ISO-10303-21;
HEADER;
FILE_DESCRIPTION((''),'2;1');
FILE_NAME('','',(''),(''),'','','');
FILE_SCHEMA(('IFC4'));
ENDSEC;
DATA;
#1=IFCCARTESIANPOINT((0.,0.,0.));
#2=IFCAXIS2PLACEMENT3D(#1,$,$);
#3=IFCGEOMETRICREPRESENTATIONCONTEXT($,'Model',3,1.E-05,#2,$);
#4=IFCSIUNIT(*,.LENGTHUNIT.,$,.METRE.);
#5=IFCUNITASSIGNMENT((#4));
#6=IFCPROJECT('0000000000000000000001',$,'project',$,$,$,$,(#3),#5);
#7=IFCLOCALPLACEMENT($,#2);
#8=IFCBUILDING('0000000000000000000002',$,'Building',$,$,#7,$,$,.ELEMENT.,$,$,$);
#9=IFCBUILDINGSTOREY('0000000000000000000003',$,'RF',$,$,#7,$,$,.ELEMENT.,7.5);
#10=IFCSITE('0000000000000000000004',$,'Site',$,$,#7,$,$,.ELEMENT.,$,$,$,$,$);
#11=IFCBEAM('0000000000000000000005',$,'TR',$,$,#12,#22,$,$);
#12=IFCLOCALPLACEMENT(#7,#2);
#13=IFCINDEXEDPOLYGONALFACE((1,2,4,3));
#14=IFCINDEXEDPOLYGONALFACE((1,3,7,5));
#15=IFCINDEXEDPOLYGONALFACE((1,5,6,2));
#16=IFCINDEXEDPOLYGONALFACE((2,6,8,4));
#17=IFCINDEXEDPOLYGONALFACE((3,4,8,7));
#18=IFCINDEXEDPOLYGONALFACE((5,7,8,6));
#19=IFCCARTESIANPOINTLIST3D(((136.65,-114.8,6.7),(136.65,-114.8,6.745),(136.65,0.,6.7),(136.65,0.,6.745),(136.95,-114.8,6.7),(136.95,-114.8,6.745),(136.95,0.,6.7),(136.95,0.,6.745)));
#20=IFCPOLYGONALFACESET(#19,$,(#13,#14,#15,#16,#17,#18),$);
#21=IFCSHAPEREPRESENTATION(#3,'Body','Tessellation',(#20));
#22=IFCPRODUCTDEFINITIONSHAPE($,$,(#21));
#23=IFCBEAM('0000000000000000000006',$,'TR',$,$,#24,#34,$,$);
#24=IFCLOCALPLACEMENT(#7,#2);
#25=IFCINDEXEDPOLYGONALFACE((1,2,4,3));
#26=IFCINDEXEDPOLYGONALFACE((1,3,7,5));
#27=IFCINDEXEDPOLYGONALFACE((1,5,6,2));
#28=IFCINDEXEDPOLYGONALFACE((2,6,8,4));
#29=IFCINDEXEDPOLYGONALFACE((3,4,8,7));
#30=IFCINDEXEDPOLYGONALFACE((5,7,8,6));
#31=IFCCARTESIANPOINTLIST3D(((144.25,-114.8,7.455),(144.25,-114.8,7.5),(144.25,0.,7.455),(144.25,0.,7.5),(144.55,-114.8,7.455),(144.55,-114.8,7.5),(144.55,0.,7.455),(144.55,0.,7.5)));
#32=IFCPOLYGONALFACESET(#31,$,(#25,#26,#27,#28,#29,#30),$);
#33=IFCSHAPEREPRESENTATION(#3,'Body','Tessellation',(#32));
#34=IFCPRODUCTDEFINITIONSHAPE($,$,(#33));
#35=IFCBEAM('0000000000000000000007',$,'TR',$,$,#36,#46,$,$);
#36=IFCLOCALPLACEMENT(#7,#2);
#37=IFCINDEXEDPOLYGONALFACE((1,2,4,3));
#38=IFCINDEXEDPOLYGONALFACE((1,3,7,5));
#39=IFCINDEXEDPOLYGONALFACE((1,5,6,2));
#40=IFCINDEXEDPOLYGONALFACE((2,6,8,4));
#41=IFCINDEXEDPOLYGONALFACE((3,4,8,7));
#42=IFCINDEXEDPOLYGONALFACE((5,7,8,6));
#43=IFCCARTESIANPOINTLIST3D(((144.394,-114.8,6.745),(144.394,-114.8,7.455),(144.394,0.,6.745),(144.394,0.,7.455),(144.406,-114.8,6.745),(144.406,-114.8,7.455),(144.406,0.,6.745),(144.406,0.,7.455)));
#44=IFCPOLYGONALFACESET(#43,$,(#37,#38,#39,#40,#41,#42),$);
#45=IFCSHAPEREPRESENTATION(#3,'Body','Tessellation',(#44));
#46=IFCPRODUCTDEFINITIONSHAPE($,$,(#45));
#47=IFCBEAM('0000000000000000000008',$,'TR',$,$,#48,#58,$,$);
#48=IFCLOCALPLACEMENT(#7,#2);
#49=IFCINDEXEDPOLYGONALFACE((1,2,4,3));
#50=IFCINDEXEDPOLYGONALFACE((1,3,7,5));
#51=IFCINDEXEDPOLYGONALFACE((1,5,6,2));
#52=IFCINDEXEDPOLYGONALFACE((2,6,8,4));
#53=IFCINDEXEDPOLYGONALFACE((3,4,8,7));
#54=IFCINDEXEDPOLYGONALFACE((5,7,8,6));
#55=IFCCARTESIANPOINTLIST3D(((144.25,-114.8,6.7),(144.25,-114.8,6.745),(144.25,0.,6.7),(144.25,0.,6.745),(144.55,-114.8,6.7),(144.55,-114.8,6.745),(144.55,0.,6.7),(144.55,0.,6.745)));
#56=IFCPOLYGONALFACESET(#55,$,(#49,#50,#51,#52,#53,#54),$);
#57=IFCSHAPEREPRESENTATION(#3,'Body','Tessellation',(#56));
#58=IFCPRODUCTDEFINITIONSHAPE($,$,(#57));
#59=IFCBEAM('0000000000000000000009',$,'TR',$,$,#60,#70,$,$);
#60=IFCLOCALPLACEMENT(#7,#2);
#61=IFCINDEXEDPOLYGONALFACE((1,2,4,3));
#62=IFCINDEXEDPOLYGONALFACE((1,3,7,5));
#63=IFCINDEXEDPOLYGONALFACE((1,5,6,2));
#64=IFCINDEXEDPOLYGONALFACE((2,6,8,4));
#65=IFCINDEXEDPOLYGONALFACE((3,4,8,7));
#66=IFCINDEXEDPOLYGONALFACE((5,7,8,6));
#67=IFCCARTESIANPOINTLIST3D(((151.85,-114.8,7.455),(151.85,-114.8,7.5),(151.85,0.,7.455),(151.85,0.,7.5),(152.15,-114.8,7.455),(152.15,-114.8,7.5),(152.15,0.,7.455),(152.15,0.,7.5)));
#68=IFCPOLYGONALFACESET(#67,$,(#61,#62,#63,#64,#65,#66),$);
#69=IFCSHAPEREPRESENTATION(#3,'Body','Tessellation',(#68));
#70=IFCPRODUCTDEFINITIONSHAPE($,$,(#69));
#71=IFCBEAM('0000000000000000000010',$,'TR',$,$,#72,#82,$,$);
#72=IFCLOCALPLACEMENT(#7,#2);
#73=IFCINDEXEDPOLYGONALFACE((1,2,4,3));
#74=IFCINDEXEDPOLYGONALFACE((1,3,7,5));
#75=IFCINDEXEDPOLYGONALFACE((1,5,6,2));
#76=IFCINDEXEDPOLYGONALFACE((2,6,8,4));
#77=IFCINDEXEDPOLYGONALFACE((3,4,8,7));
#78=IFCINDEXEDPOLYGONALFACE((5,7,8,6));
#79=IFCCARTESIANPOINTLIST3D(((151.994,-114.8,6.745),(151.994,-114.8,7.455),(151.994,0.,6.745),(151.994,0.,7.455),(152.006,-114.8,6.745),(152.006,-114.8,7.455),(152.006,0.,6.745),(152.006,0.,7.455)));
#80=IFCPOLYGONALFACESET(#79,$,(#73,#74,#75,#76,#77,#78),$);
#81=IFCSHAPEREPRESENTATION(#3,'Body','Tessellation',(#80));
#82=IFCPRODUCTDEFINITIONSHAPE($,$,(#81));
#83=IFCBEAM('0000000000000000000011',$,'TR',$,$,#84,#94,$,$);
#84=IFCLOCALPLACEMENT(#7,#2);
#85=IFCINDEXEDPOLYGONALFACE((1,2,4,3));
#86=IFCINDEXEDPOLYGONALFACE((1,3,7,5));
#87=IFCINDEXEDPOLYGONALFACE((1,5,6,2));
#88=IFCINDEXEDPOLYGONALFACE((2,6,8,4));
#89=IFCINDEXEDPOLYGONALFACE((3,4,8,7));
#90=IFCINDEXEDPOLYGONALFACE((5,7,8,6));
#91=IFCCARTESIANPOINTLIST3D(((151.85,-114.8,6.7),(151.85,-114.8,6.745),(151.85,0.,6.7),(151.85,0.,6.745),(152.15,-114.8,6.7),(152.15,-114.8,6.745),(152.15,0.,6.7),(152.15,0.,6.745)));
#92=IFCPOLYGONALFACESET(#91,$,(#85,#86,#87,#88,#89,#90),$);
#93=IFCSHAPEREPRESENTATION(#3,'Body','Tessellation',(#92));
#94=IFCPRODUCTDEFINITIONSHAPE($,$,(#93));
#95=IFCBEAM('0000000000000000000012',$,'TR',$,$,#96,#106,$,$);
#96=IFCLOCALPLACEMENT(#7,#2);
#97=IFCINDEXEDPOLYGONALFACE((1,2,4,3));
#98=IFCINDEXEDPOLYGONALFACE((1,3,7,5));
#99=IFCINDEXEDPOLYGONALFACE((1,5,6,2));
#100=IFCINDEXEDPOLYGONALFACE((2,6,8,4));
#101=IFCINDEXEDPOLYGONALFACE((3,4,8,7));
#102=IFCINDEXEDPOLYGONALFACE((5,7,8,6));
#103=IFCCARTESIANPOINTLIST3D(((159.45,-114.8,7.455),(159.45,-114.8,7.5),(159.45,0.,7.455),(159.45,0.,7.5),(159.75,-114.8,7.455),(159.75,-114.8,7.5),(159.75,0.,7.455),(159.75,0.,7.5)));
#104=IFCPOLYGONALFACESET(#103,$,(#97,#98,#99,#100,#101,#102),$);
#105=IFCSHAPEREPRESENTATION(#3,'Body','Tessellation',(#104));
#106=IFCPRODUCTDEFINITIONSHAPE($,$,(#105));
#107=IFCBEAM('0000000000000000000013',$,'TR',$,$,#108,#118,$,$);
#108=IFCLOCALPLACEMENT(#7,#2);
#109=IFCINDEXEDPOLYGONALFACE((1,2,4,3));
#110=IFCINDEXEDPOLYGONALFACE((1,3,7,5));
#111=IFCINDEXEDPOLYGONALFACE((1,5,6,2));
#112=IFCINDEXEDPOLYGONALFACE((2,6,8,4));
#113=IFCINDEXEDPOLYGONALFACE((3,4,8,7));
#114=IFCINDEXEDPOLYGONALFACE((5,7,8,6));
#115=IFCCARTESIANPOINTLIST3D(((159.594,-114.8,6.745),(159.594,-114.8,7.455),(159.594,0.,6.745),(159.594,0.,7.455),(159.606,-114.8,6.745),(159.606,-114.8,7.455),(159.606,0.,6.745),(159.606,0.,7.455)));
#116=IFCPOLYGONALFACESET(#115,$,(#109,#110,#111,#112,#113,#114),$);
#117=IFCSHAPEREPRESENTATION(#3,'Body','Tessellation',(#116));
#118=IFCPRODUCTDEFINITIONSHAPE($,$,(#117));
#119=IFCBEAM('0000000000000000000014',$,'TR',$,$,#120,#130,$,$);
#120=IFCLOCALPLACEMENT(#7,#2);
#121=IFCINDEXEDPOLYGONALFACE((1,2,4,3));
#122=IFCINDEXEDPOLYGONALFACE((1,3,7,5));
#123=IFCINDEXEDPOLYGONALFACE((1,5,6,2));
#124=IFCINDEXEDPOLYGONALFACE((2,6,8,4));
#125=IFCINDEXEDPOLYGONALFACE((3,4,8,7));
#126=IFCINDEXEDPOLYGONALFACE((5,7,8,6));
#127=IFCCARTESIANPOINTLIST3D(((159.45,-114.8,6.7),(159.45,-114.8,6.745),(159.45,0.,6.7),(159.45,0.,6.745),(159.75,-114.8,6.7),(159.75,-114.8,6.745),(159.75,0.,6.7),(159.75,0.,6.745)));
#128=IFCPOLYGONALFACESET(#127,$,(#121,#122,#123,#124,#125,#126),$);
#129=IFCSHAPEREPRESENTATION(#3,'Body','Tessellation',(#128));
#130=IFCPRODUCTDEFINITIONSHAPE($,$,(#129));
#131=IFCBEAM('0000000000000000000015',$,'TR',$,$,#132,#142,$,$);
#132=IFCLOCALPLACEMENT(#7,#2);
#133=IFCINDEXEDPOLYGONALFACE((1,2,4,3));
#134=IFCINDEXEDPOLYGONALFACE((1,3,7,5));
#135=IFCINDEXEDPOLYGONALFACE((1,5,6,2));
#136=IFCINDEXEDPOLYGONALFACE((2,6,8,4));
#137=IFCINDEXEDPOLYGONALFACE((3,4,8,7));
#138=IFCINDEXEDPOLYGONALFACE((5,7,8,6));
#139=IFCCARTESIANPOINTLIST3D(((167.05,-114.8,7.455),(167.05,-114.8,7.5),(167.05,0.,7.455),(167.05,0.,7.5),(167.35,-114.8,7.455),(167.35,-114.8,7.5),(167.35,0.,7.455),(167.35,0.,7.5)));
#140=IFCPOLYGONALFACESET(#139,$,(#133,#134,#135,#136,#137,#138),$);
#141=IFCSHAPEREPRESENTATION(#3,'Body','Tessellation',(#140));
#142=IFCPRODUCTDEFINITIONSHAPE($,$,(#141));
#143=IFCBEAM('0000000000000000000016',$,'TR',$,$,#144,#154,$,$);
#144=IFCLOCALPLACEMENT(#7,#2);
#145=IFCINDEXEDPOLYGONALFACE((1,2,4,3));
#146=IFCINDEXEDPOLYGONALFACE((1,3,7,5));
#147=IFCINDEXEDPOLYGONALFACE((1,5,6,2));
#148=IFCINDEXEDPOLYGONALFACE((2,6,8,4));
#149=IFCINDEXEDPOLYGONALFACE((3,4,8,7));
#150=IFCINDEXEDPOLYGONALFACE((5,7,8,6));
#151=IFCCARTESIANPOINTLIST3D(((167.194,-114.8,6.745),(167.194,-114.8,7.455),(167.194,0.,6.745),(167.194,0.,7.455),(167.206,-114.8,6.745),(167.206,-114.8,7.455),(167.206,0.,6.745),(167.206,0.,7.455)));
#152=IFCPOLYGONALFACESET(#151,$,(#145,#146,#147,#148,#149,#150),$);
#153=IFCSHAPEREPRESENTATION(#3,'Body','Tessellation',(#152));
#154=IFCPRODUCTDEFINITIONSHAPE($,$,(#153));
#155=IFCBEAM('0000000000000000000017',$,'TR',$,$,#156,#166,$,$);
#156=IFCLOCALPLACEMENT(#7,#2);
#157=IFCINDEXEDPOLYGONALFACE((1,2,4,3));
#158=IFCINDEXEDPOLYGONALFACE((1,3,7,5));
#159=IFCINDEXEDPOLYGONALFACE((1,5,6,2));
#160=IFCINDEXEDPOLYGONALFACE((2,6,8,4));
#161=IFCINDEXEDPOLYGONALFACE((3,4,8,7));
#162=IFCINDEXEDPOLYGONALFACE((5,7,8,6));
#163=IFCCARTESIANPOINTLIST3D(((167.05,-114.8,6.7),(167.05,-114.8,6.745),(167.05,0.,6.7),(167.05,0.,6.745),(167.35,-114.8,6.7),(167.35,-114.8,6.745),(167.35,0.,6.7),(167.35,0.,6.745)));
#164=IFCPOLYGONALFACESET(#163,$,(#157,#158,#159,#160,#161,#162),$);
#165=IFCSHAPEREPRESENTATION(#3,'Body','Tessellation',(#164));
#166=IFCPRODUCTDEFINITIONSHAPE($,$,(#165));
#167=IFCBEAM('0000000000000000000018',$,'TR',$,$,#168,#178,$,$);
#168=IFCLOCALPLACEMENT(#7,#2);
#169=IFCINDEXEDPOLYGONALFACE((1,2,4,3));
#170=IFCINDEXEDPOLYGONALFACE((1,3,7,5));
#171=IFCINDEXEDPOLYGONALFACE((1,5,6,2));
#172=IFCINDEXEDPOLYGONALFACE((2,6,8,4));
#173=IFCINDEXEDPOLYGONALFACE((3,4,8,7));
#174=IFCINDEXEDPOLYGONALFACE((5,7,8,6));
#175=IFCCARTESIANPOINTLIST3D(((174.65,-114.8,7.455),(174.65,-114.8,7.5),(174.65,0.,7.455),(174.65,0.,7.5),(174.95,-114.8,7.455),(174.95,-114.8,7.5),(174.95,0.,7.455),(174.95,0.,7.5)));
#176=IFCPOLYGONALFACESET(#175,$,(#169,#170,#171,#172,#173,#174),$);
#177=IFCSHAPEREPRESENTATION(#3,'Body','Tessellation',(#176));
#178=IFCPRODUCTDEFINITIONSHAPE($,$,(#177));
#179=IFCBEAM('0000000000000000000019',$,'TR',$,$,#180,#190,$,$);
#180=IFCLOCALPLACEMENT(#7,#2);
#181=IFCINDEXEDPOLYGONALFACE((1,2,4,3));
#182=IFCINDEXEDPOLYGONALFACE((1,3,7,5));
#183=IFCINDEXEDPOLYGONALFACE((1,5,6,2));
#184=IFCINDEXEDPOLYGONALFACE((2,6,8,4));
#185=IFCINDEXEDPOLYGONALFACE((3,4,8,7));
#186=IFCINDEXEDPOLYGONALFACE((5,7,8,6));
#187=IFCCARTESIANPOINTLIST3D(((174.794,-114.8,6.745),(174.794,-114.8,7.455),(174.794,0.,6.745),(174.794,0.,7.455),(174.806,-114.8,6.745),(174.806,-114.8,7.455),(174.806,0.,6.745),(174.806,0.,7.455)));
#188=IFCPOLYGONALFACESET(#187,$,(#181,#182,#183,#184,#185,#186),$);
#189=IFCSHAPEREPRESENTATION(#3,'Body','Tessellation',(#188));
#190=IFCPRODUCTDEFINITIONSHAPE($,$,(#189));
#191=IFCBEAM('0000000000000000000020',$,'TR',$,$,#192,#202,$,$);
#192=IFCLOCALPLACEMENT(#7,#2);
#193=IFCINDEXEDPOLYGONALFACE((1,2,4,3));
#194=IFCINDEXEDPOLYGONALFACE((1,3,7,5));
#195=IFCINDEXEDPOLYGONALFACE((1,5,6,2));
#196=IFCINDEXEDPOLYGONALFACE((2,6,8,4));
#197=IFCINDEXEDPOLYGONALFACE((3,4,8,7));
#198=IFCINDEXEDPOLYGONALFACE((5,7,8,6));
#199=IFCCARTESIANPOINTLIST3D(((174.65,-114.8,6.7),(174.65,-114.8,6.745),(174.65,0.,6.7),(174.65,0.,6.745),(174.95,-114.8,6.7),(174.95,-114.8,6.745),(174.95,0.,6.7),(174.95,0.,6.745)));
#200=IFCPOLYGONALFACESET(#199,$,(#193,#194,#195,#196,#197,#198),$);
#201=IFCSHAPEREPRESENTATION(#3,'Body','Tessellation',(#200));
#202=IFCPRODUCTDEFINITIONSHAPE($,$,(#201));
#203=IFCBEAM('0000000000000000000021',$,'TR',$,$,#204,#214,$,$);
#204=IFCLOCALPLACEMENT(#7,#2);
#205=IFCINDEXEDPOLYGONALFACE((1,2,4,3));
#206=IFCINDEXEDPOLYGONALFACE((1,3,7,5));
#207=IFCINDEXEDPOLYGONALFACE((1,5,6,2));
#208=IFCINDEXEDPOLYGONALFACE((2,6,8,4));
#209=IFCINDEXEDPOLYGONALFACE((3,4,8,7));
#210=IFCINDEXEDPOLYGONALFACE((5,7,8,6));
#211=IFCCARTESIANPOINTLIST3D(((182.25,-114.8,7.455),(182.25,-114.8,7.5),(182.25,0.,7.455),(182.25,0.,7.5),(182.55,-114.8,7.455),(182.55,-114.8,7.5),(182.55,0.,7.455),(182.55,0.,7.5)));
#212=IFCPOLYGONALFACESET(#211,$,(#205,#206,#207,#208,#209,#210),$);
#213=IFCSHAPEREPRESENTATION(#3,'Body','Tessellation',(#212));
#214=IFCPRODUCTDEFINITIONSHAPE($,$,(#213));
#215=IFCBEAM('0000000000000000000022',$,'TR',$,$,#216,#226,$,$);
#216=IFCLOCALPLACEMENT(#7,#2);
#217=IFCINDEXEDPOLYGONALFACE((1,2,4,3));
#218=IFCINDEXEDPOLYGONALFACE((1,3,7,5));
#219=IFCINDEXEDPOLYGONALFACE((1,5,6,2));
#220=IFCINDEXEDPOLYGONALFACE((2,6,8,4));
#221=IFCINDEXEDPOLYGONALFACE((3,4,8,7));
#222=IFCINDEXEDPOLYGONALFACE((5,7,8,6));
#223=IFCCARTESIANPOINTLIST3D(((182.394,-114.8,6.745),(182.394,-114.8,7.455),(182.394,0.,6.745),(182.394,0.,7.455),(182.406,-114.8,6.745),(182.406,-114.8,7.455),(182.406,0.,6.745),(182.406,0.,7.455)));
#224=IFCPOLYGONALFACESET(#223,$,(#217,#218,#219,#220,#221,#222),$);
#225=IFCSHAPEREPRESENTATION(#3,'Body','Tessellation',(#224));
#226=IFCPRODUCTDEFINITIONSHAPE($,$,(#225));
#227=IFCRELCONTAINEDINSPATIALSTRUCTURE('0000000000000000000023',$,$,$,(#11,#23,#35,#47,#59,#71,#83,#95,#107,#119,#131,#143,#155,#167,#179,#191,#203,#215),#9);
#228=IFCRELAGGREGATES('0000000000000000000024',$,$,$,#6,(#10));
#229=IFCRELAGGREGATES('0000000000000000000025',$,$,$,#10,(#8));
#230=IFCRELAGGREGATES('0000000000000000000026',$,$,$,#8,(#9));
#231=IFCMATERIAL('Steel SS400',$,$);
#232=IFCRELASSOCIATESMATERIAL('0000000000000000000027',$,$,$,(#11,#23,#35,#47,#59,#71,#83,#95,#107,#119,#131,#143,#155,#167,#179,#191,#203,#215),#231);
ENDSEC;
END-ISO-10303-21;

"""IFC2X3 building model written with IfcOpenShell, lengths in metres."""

from ifc_helpers import new_model, si_unit, frame, origin, origin_2d, place, context, project, spatial, rectangle, extrude, material, element, save


model = new_model("IFC2X3")

# Units and contexts
model_context = context("Model", 3, precision=1e-05, world=origin())
ifc_project = project(units=[si_unit("LENGTHUNIT", "METRE")], contexts=[model_context])

# Site, building, storey
placement = place(None, origin())
site = spatial("IfcSite", under=ifc_project, at=placement, Name="Site", CompositionType="ELEMENT")
building = spatial("IfcBuilding", under=site, at=placement, Name="Building", CompositionType="ELEMENT")
storey = spatial("IfcBuildingStorey", under=building, at=placement, Name="RF", CompositionType="ELEMENT", Elevation=7.5)

# Beams
ifc_material = material(Name="Steel SS400")
for number, where, name in (
    (1, (136.8, -57.4, 6.7), "TR"),
    (2, (144.4, -57.4, 7.455), "TR"),
):
    element("IfcBeam", number, at=place(None, frame(where)), inside=storey, material=ifc_material, Name=name, context=model_context, shape_type="SweptSolid", body=[
        extrude(rectangle(XDim=0.3, YDim=114.8, at=origin_2d()), origin(), (0.0, 0.0, 1.0), 0.045),
    ])
beam_1_placement = place(None, frame((144.4, -57.4, 6.745)))
element("IfcBeam", 3, at=beam_1_placement, inside=storey, material=ifc_material, Name="TR", context=model_context, shape_type="SweptSolid", body=[
    extrude(rectangle(XDim=0.012, YDim=114.8, at=origin_2d()), origin(), (0.0, 0.0, 1.0), 0.71),
])
for number, where, name in (
    (4, (144.4, -57.4, 6.7), "TR"),
    (5, (152.0, -57.4, 7.455), "TR"),
):
    element("IfcBeam", number, at=place(None, frame(where)), inside=storey, material=ifc_material, Name=name, context=model_context, shape_type="SweptSolid", body=[
        extrude(rectangle(XDim=0.3, YDim=114.8, at=origin_2d()), origin(), (0.0, 0.0, 1.0), 0.045),
    ])
beam_2_placement = place(None, frame((152.0, -57.4, 6.745)))
element("IfcBeam", 6, at=beam_2_placement, inside=storey, material=ifc_material, Name="TR", context=model_context, shape_type="SweptSolid", body=[
    extrude(rectangle(XDim=0.012, YDim=114.8, at=origin_2d()), origin(), (0.0, 0.0, 1.0), 0.71),
])
for number, where, name in (
    (7, (152.0, -57.4, 6.7), "TR"),
    (8, (159.6, -57.4, 7.455), "TR"),
):
    element("IfcBeam", number, at=place(None, frame(where)), inside=storey, material=ifc_material, Name=name, context=model_context, shape_type="SweptSolid", body=[
        extrude(rectangle(XDim=0.3, YDim=114.8, at=origin_2d()), origin(), (0.0, 0.0, 1.0), 0.045),
    ])
beam_3_placement = place(None, frame((159.6, -57.4, 6.745)))
element("IfcBeam", 9, at=beam_3_placement, inside=storey, material=ifc_material, Name="TR", context=model_context, shape_type="SweptSolid", body=[
    extrude(rectangle(XDim=0.012, YDim=114.8, at=origin_2d()), origin(), (0.0, 0.0, 1.0), 0.71),
])
for number, where, name in (
    (10, (159.6, -57.4, 6.7), "TR"),
    (11, (167.2, -57.4, 7.455), "TR"),
):
    element("IfcBeam", number, at=place(None, frame(where)), inside=storey, material=ifc_material, Name=name, context=model_context, shape_type="SweptSolid", body=[
        extrude(rectangle(XDim=0.3, YDim=114.8, at=origin_2d()), origin(), (0.0, 0.0, 1.0), 0.045),
    ])
beam_4_placement = place(None, frame((167.2, -57.4, 6.745)))
element("IfcBeam", 12, at=beam_4_placement, inside=storey, material=ifc_material, Name="TR", context=model_context, shape_type="SweptSolid", body=[
    extrude(rectangle(XDim=0.012, YDim=114.8, at=origin_2d()), origin(), (0.0, 0.0, 1.0), 0.71),
])
for number, where, name in (
    (13, (167.2, -57.4, 6.7), "TR"),
    (14, (174.8, -57.4, 7.455), "TR"),
):
    element("IfcBeam", number, at=place(None, frame(where)), inside=storey, material=ifc_material, Name=name, context=model_context, shape_type="SweptSolid", body=[
        extrude(rectangle(XDim=0.3, YDim=114.8, at=origin_2d()), origin(), (0.0, 0.0, 1.0), 0.045),
    ])
beam_5_placement = place(None, frame((174.8, -57.4, 6.745)))
element("IfcBeam", 15, at=beam_5_placement, inside=storey, material=ifc_material, Name="TR", context=model_context, shape_type="SweptSolid", body=[
    extrude(rectangle(XDim=0.012, YDim=114.8, at=origin_2d()), origin(), (0.0, 0.0, 1.0), 0.71),
])
for number, where, name in (
    (16, (174.8, -57.4, 6.7), "TR"),
    (17, (182.4, -57.4, 7.455), "TR"),
):
    element("IfcBeam", number, at=place(None, frame(where)), inside=storey, material=ifc_material, Name=name, context=model_context, shape_type="SweptSolid", body=[
        extrude(rectangle(XDim=0.3, YDim=114.8, at=origin_2d()), origin(), (0.0, 0.0, 1.0), 0.045),
    ])
beam_6_placement = place(None, frame((182.4, -57.4, 6.745)))
element("IfcBeam", 18, at=beam_6_placement, inside=storey, material=ifc_material, Name="TR", context=model_context, shape_type="SweptSolid", body=[
    extrude(rectangle(XDim=0.012, YDim=114.8, at=origin_2d()), origin(), (0.0, 0.0, 1.0), 0.71),
])

save(model, "model.ifc")
